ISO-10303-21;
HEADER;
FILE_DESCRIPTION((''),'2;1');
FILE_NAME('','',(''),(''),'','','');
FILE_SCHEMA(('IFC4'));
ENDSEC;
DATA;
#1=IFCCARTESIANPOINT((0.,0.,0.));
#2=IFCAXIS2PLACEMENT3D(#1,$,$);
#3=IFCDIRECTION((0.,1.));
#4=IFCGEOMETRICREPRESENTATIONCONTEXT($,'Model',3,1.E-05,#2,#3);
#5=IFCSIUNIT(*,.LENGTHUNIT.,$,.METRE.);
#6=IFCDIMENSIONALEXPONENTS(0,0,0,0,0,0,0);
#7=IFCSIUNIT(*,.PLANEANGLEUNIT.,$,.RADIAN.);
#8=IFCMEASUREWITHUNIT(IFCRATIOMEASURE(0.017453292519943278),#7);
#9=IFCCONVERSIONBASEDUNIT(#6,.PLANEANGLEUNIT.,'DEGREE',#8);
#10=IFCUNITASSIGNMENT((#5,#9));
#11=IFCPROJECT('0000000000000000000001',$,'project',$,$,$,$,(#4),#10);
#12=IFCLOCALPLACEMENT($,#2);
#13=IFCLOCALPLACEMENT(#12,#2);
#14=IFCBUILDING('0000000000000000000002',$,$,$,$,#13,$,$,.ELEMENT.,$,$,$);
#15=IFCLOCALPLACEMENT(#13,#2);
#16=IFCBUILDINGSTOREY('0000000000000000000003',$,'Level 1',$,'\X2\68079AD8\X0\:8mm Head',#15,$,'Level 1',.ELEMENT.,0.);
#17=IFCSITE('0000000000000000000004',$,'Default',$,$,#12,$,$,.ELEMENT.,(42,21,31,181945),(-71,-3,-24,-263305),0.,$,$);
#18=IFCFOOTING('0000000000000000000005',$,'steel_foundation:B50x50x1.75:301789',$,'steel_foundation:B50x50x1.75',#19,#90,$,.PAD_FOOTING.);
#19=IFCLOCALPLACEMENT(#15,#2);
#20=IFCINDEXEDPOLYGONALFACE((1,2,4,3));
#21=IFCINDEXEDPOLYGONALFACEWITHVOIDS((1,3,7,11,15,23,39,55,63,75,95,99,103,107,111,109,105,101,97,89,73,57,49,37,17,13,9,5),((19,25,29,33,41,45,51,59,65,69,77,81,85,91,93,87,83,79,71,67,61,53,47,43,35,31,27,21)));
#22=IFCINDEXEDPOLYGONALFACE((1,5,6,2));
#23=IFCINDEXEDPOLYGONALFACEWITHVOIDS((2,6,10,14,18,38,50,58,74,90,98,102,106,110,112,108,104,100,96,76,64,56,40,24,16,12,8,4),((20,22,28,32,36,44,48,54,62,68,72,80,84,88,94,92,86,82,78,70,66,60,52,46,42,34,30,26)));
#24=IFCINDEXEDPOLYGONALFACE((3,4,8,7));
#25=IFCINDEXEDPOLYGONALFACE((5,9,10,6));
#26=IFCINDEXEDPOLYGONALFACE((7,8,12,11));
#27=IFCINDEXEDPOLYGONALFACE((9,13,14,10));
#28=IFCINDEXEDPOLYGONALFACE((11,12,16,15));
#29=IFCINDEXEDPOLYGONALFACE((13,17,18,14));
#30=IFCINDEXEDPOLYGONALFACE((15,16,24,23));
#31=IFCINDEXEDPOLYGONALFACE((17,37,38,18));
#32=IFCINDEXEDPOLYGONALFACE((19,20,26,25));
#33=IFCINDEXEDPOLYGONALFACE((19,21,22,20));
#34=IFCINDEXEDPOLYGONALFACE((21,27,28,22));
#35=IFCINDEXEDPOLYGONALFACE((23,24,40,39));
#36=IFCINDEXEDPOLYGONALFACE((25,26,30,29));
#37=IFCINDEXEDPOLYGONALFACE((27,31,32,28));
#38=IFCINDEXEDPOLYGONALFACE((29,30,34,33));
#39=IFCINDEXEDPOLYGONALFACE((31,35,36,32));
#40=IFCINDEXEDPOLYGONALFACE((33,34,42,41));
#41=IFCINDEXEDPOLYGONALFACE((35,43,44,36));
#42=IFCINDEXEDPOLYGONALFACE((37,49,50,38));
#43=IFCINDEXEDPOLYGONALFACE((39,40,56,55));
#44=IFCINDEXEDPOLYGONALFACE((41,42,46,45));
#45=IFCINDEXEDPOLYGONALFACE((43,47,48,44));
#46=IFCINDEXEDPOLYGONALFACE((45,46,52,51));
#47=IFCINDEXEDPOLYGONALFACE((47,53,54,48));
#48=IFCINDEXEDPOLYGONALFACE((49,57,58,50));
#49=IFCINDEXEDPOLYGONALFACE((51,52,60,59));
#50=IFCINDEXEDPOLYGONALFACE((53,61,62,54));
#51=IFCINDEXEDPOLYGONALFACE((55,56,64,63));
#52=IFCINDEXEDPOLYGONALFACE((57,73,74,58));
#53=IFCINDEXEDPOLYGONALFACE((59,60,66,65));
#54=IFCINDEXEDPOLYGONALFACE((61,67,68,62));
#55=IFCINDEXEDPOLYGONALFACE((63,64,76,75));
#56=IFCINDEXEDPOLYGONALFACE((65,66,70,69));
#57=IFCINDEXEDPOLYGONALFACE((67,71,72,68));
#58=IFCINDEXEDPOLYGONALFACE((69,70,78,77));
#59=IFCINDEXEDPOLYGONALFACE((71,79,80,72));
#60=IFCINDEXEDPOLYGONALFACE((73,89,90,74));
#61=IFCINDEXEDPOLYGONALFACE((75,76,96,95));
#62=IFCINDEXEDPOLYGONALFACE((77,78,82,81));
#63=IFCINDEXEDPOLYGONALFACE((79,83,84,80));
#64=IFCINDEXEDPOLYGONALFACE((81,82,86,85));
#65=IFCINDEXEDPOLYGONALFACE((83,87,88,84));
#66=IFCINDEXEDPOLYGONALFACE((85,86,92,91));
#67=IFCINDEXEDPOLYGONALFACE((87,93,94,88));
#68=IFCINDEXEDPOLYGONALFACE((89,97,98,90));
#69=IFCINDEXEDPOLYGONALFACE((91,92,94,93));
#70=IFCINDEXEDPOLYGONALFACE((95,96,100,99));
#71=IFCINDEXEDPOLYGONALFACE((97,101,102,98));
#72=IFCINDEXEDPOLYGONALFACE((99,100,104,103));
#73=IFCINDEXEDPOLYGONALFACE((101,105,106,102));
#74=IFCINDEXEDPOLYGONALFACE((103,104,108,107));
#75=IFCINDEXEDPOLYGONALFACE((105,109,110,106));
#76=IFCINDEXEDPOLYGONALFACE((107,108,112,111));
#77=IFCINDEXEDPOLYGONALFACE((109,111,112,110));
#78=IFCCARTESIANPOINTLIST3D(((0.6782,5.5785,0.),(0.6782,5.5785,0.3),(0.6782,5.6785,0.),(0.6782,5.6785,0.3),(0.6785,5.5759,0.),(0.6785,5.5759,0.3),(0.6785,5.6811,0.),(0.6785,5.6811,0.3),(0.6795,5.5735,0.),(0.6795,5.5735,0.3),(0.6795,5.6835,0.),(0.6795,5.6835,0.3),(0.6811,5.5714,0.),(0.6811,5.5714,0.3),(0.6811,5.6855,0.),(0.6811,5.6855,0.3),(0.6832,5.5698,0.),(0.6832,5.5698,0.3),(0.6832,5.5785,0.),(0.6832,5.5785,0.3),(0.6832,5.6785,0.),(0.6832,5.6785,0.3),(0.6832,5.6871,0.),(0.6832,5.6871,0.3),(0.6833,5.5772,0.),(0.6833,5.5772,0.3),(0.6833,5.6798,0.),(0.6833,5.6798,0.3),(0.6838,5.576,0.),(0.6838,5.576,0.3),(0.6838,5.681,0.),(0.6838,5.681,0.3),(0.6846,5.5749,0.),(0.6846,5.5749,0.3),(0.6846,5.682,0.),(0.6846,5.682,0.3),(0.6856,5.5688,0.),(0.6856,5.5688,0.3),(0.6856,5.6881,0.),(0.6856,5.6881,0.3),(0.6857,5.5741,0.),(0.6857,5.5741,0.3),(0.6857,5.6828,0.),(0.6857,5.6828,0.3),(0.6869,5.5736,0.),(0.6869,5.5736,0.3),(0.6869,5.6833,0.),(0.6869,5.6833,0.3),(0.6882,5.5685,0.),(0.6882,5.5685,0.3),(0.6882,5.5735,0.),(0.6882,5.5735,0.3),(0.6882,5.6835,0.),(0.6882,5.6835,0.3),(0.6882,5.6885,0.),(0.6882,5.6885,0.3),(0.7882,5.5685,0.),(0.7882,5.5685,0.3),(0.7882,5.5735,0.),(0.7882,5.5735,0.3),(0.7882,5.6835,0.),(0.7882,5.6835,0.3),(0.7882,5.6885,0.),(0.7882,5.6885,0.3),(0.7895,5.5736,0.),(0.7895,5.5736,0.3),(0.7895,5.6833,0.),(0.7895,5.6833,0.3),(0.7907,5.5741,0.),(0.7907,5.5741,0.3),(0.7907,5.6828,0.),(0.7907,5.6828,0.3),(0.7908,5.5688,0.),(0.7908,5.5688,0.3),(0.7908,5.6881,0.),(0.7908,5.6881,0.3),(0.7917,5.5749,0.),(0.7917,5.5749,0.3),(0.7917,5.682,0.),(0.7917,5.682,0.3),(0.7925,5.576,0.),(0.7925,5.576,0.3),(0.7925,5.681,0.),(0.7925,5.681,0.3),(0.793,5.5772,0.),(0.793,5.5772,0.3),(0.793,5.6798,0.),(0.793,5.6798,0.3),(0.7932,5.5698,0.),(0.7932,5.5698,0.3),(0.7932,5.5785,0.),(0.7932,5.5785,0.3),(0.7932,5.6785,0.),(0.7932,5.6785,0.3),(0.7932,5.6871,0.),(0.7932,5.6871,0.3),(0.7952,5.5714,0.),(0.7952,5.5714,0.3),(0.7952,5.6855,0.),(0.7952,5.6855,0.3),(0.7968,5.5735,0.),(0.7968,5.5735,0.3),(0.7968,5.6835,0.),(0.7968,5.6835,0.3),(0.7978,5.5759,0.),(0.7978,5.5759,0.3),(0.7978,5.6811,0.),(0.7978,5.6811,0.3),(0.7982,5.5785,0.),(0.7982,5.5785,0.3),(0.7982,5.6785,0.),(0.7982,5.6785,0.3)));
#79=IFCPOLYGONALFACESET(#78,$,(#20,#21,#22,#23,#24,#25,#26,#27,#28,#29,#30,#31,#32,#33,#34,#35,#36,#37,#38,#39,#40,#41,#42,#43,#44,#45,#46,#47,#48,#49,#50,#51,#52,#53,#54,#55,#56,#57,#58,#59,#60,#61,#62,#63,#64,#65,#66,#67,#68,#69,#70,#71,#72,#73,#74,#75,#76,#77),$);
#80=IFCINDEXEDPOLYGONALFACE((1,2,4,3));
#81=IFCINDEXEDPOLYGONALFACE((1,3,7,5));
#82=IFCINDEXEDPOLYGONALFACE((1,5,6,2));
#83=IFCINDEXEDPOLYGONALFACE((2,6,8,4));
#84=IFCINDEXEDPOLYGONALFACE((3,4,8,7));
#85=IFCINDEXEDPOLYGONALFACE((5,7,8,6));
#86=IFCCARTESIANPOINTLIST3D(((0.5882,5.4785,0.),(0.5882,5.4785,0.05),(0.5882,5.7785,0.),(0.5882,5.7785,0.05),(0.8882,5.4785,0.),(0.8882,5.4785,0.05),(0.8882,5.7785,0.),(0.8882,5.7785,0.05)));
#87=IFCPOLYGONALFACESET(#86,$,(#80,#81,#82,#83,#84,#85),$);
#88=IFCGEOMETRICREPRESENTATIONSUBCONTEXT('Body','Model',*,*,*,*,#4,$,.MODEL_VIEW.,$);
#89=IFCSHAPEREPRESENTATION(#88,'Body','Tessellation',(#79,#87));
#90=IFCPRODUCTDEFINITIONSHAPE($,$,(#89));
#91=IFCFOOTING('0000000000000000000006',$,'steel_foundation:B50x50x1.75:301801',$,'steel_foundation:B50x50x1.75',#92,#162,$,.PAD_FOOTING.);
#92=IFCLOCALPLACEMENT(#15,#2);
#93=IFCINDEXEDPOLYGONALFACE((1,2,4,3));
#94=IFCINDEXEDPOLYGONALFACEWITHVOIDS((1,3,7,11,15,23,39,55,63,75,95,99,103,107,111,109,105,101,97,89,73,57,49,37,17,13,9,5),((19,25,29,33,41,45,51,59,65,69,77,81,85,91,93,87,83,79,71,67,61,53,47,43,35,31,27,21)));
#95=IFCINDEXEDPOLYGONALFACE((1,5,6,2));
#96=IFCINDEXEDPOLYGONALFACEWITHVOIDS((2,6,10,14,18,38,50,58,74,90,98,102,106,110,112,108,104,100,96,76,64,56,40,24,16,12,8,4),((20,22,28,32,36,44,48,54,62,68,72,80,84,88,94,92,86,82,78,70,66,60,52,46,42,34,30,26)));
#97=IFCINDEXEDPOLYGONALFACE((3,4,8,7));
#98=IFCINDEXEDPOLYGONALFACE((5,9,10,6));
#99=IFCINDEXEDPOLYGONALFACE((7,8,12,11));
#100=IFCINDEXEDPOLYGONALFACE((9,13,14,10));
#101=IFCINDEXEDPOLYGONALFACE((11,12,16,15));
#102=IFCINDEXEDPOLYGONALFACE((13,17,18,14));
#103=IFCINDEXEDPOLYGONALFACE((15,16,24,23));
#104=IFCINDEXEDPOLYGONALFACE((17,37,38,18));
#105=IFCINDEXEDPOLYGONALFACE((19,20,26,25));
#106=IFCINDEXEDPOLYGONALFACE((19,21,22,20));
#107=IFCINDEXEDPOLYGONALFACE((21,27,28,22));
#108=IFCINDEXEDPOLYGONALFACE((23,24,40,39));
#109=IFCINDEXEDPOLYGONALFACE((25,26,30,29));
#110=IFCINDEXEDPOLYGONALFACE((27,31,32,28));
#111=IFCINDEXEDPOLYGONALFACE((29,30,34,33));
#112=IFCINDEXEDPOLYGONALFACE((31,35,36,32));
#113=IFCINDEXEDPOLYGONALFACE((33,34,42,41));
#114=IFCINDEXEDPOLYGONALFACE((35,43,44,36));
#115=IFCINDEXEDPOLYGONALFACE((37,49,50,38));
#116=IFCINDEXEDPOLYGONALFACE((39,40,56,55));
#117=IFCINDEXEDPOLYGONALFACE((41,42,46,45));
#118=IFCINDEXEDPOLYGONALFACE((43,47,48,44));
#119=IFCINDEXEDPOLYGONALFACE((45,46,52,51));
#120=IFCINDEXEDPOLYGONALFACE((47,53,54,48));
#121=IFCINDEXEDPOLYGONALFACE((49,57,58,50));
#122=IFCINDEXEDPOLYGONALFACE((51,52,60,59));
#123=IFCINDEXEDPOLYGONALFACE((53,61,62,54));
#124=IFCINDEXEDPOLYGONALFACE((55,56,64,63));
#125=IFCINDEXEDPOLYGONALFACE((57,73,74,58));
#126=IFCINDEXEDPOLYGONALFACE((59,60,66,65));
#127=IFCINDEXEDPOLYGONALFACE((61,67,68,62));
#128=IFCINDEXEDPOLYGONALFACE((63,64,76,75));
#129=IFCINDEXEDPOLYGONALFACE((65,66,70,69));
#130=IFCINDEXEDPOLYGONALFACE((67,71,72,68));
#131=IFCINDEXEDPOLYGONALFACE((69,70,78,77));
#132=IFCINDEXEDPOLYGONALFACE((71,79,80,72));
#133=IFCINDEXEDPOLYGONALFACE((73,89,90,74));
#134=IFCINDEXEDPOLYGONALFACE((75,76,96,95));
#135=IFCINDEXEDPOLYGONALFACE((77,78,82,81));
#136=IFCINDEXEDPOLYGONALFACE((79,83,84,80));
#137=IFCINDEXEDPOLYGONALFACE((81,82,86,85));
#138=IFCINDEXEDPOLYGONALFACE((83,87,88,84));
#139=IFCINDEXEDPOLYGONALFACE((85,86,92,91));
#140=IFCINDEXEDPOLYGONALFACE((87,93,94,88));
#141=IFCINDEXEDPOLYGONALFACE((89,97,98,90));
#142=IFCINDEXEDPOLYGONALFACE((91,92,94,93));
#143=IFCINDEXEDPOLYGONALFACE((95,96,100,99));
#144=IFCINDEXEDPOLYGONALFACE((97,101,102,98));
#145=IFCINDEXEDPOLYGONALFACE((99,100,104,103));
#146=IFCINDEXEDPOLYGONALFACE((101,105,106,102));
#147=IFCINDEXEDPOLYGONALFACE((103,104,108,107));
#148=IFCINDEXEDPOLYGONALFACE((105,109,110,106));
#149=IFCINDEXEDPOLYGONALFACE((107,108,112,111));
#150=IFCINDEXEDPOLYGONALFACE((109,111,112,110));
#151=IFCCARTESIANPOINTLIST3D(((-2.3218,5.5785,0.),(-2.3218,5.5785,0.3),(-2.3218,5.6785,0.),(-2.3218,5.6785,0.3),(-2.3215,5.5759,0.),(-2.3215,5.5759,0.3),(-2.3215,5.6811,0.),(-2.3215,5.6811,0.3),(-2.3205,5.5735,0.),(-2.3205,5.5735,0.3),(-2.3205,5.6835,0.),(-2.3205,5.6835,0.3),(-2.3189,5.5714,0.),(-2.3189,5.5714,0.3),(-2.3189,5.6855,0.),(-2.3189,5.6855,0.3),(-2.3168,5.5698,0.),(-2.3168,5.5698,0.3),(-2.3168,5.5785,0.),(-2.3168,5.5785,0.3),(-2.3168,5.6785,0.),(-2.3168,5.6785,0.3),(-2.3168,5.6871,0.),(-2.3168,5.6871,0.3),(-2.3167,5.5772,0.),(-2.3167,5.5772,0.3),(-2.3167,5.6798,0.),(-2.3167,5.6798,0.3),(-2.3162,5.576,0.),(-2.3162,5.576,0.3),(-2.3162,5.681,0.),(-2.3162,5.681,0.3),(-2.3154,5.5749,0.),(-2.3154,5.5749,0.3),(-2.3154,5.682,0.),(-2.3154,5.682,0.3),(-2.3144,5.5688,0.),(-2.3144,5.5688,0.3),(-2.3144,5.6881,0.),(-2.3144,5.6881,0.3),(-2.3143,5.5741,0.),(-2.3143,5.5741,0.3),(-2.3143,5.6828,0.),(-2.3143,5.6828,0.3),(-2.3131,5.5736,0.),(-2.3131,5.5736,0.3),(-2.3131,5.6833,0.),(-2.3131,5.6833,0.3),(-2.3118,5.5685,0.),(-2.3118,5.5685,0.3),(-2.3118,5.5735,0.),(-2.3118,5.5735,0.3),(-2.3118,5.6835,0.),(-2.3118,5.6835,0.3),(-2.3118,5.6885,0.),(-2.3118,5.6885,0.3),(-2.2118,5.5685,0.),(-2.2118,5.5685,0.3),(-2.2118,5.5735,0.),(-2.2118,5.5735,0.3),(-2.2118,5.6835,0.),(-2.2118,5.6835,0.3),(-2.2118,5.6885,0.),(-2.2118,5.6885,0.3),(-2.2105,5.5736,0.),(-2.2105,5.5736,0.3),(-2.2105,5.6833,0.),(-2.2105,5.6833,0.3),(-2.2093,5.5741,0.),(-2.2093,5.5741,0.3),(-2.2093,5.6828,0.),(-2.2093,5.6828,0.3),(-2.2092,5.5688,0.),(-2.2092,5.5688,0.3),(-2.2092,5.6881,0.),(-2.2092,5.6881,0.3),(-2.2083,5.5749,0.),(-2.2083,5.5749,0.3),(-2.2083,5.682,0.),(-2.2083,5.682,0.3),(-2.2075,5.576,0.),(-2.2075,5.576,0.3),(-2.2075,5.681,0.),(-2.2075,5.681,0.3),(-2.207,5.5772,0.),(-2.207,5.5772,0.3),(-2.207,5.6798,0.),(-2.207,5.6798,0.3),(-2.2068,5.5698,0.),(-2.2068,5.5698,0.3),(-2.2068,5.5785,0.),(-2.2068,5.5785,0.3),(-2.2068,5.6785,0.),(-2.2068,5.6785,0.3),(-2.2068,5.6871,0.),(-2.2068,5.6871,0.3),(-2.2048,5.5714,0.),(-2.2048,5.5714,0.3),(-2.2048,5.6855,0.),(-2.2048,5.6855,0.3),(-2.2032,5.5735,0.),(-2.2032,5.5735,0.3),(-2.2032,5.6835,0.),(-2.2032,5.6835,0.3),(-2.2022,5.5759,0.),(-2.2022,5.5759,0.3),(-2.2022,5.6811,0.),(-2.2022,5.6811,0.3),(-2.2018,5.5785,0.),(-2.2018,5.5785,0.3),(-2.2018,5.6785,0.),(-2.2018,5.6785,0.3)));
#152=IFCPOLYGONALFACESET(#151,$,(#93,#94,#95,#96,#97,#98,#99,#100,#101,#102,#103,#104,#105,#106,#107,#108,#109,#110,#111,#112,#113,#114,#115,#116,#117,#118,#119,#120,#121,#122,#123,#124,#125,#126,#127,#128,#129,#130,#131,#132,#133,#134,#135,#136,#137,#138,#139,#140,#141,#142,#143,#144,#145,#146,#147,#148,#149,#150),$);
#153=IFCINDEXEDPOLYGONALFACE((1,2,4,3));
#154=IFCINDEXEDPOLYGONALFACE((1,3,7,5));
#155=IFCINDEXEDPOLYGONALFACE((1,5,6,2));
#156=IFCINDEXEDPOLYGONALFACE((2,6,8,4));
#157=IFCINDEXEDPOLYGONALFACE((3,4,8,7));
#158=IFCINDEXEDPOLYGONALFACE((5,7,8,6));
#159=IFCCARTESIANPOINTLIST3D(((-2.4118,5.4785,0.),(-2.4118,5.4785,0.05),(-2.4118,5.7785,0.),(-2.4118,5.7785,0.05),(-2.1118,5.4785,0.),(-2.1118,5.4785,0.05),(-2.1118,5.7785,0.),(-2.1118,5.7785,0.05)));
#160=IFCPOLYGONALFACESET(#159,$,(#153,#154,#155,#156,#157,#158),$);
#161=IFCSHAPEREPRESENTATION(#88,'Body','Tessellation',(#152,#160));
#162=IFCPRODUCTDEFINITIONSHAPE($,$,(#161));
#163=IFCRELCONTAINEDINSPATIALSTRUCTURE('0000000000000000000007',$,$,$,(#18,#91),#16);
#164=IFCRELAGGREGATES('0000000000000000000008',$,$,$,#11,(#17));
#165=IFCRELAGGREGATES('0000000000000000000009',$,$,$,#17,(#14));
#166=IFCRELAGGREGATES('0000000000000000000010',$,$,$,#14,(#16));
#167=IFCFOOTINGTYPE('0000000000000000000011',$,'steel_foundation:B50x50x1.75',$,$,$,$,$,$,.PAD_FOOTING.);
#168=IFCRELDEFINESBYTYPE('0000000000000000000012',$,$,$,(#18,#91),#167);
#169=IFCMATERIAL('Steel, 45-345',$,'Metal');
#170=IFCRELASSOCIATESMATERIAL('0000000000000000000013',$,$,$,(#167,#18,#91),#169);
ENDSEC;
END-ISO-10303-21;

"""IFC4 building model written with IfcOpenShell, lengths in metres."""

from ifc_helpers import new_model, entity, si_unit, converted_unit, direction, frame, frame_2d, origin, place, context, subcontext, project, spatial, polyline, circle_curve, parameter, trimmed, segment, composite_curve, rectangle, outline, extrude, source, transform, mapped, material, type_object, type_shapes, element, save


model = new_model("IFC4")

# Units and contexts
model_context = context("Model", 3, precision=1e-05, world=origin(), true_north=direction((0.0, 1.0)))
body_context = subcontext(model_context, "Body", "Model", "MODEL_VIEW")
ifc_project = project(units=[si_unit("LENGTHUNIT", "METRE"), converted_unit("PLANEANGLEUNIT", "DEGREE", entity("IfcRatioMeasure", 0.017453292519943278), si_unit("PLANEANGLEUNIT", "RADIAN"), dimensions=[0, 0, 0, 0, 0, 0, 0])], contexts=[model_context])

# Site, building, storey
site_placement = place(None, origin())
site = spatial("IfcSite", under=ifc_project, at=site_placement, Name="Default", CompositionType="ELEMENT", RefLatitude=(42, 21, 31, 181945), RefLongitude=(-71, -3, -24, -263305), RefElevation=0.0)
building_placement = place(site_placement, origin())
building = spatial("IfcBuilding", under=site, at=building_placement, CompositionType="ELEMENT")
storey_placement = place(building_placement, origin())
storey = spatial("IfcBuildingStorey", under=building, at=storey_placement, Name="Level 1", ObjectType="标高:8mm Head", LongName="Level 1", CompositionType="ELEMENT", Elevation=0.0)

# Footings
ifc_material_1 = material(Name="Steel, 45-345", Category="Metal")
footing_type = type_object("IfcFootingType", Name="steel_foundation:B50x50x1.75", PredefinedType="PAD_FOOTING", material=ifc_material_1)
shared_shape_1 = source(origin(), body_context, "Body", "SweptSolid", [
    extrude(outline(composite_curve([segment(polyline([(-0.05, -0.06), (0.05, -0.06)]), True, "CONTINUOUS"), segment(trimmed(circle_curve(frame_2d((0.05, -0.05), x_axis=(-1.0, 0.0)), 0.01), [parameter(90.0)], [parameter(180.0)], True, "PARAMETER"), True, "CONTINUOUS"), segment(polyline([(0.06, -0.05), (0.06, 0.05)]), True, "CONTINUOUS"), segment(trimmed(circle_curve(frame_2d((0.05, 0.05), x_axis=(-1.0, 0.0)), 0.01), [parameter(180.0)], [parameter(270.0)], True, "PARAMETER"), True, "CONTINUOUS"), segment(polyline([(0.05, 0.06), (-0.05, 0.06)]), True, "CONTINUOUS"), segment(trimmed(circle_curve(frame_2d((-0.05, 0.05), x_axis=(-1.0, 0.0)), 0.01), [parameter(270.0)], [parameter(360.0)], True, "PARAMETER"), True, "CONTINUOUS"), segment(polyline([(-0.06, 0.05), (-0.06, -0.05)]), True, "CONTINUOUS"), segment(trimmed(circle_curve(frame_2d((-0.05, -0.05), x_axis=(-1.0, 0.0)), 0.01), [parameter(360.0)], [parameter(90.0)], True, "PARAMETER"), True, "CONTINUOUS")], self_intersect=False), holes=[composite_curve([segment(trimmed(circle_curve(frame_2d((-0.05, -0.05), x_axis=(-1.0, 0.0)), 0.005), [parameter(0.0)], [parameter(90.0)], True, "PARAMETER"), False, "CONTINUOUS"), segment(polyline([(-0.055, -0.05), (-0.055, 0.05)]), True, "CONTINUOUS"), segment(trimmed(circle_curve(frame_2d((-0.05, 0.05), x_axis=(-1.0, 0.0)), 0.005), [parameter(270.0)], [parameter(360.0)], True, "PARAMETER"), False, "CONTINUOUS"), segment(polyline([(-0.05, 0.055), (0.05, 0.055)]), True, "CONTINUOUS"), segment(trimmed(circle_curve(frame_2d((0.05, 0.05), x_axis=(-1.0, 0.0)), 0.005), [parameter(180.0)], [parameter(270.0)], True, "PARAMETER"), False, "CONTINUOUS"), segment(polyline([(0.055, 0.05), (0.055, -0.05)]), True, "CONTINUOUS"), segment(trimmed(circle_curve(frame_2d((0.05, -0.05), x_axis=(-1.0, 0.0)), 0.005), [parameter(90.0)], [parameter(180.0)], True, "PARAMETER"), False, "CONTINUOUS"), segment(polyline([(0.05, -0.055), (-0.05, -0.055)]), True, "CONTINUOUS")], self_intersect=False)]), frame((0.0, 0.0, 0.0), z_axis=(0.0, 0.0, 1.0), x_axis=(-1.0, 0.0, 0.0)), (0.0, 0.0, 1.0), 0.3),
    extrude(rectangle(XDim=0.3, YDim=0.3, at=frame_2d((0.0, 0.0), x_axis=(1.0, 0.0))), frame((0.0, 0.0, 0.0), z_axis=(0.0, 0.0, 1.0), x_axis=(-1.0, 0.0, 0.0)), (0.0, 0.0, 1.0), 0.05),
])
type_shapes(footing_type, [shared_shape_1])
for number, where, name in (
    (1, (0.7382, 5.6285, 0.0), "steel_foundation:B50x50x1.75:301789"),
    (2, (-2.2618, 5.6285, 0.0), "steel_foundation:B50x50x1.75:301801"),
):
    element("IfcFooting", number, at=place(storey_placement, frame(where)), inside=storey, type_object=footing_type, material=ifc_material_1, Name=name, ObjectType="steel_foundation:B50x50x1.75", PredefinedType="PAD_FOOTING", context=body_context, shape_type="MappedRepresentation", body=[
        mapped(shared_shape_1, transform((0.0, 0.0, 0.0), scale=1.0)),
    ])

save(model, "model.ifc")
